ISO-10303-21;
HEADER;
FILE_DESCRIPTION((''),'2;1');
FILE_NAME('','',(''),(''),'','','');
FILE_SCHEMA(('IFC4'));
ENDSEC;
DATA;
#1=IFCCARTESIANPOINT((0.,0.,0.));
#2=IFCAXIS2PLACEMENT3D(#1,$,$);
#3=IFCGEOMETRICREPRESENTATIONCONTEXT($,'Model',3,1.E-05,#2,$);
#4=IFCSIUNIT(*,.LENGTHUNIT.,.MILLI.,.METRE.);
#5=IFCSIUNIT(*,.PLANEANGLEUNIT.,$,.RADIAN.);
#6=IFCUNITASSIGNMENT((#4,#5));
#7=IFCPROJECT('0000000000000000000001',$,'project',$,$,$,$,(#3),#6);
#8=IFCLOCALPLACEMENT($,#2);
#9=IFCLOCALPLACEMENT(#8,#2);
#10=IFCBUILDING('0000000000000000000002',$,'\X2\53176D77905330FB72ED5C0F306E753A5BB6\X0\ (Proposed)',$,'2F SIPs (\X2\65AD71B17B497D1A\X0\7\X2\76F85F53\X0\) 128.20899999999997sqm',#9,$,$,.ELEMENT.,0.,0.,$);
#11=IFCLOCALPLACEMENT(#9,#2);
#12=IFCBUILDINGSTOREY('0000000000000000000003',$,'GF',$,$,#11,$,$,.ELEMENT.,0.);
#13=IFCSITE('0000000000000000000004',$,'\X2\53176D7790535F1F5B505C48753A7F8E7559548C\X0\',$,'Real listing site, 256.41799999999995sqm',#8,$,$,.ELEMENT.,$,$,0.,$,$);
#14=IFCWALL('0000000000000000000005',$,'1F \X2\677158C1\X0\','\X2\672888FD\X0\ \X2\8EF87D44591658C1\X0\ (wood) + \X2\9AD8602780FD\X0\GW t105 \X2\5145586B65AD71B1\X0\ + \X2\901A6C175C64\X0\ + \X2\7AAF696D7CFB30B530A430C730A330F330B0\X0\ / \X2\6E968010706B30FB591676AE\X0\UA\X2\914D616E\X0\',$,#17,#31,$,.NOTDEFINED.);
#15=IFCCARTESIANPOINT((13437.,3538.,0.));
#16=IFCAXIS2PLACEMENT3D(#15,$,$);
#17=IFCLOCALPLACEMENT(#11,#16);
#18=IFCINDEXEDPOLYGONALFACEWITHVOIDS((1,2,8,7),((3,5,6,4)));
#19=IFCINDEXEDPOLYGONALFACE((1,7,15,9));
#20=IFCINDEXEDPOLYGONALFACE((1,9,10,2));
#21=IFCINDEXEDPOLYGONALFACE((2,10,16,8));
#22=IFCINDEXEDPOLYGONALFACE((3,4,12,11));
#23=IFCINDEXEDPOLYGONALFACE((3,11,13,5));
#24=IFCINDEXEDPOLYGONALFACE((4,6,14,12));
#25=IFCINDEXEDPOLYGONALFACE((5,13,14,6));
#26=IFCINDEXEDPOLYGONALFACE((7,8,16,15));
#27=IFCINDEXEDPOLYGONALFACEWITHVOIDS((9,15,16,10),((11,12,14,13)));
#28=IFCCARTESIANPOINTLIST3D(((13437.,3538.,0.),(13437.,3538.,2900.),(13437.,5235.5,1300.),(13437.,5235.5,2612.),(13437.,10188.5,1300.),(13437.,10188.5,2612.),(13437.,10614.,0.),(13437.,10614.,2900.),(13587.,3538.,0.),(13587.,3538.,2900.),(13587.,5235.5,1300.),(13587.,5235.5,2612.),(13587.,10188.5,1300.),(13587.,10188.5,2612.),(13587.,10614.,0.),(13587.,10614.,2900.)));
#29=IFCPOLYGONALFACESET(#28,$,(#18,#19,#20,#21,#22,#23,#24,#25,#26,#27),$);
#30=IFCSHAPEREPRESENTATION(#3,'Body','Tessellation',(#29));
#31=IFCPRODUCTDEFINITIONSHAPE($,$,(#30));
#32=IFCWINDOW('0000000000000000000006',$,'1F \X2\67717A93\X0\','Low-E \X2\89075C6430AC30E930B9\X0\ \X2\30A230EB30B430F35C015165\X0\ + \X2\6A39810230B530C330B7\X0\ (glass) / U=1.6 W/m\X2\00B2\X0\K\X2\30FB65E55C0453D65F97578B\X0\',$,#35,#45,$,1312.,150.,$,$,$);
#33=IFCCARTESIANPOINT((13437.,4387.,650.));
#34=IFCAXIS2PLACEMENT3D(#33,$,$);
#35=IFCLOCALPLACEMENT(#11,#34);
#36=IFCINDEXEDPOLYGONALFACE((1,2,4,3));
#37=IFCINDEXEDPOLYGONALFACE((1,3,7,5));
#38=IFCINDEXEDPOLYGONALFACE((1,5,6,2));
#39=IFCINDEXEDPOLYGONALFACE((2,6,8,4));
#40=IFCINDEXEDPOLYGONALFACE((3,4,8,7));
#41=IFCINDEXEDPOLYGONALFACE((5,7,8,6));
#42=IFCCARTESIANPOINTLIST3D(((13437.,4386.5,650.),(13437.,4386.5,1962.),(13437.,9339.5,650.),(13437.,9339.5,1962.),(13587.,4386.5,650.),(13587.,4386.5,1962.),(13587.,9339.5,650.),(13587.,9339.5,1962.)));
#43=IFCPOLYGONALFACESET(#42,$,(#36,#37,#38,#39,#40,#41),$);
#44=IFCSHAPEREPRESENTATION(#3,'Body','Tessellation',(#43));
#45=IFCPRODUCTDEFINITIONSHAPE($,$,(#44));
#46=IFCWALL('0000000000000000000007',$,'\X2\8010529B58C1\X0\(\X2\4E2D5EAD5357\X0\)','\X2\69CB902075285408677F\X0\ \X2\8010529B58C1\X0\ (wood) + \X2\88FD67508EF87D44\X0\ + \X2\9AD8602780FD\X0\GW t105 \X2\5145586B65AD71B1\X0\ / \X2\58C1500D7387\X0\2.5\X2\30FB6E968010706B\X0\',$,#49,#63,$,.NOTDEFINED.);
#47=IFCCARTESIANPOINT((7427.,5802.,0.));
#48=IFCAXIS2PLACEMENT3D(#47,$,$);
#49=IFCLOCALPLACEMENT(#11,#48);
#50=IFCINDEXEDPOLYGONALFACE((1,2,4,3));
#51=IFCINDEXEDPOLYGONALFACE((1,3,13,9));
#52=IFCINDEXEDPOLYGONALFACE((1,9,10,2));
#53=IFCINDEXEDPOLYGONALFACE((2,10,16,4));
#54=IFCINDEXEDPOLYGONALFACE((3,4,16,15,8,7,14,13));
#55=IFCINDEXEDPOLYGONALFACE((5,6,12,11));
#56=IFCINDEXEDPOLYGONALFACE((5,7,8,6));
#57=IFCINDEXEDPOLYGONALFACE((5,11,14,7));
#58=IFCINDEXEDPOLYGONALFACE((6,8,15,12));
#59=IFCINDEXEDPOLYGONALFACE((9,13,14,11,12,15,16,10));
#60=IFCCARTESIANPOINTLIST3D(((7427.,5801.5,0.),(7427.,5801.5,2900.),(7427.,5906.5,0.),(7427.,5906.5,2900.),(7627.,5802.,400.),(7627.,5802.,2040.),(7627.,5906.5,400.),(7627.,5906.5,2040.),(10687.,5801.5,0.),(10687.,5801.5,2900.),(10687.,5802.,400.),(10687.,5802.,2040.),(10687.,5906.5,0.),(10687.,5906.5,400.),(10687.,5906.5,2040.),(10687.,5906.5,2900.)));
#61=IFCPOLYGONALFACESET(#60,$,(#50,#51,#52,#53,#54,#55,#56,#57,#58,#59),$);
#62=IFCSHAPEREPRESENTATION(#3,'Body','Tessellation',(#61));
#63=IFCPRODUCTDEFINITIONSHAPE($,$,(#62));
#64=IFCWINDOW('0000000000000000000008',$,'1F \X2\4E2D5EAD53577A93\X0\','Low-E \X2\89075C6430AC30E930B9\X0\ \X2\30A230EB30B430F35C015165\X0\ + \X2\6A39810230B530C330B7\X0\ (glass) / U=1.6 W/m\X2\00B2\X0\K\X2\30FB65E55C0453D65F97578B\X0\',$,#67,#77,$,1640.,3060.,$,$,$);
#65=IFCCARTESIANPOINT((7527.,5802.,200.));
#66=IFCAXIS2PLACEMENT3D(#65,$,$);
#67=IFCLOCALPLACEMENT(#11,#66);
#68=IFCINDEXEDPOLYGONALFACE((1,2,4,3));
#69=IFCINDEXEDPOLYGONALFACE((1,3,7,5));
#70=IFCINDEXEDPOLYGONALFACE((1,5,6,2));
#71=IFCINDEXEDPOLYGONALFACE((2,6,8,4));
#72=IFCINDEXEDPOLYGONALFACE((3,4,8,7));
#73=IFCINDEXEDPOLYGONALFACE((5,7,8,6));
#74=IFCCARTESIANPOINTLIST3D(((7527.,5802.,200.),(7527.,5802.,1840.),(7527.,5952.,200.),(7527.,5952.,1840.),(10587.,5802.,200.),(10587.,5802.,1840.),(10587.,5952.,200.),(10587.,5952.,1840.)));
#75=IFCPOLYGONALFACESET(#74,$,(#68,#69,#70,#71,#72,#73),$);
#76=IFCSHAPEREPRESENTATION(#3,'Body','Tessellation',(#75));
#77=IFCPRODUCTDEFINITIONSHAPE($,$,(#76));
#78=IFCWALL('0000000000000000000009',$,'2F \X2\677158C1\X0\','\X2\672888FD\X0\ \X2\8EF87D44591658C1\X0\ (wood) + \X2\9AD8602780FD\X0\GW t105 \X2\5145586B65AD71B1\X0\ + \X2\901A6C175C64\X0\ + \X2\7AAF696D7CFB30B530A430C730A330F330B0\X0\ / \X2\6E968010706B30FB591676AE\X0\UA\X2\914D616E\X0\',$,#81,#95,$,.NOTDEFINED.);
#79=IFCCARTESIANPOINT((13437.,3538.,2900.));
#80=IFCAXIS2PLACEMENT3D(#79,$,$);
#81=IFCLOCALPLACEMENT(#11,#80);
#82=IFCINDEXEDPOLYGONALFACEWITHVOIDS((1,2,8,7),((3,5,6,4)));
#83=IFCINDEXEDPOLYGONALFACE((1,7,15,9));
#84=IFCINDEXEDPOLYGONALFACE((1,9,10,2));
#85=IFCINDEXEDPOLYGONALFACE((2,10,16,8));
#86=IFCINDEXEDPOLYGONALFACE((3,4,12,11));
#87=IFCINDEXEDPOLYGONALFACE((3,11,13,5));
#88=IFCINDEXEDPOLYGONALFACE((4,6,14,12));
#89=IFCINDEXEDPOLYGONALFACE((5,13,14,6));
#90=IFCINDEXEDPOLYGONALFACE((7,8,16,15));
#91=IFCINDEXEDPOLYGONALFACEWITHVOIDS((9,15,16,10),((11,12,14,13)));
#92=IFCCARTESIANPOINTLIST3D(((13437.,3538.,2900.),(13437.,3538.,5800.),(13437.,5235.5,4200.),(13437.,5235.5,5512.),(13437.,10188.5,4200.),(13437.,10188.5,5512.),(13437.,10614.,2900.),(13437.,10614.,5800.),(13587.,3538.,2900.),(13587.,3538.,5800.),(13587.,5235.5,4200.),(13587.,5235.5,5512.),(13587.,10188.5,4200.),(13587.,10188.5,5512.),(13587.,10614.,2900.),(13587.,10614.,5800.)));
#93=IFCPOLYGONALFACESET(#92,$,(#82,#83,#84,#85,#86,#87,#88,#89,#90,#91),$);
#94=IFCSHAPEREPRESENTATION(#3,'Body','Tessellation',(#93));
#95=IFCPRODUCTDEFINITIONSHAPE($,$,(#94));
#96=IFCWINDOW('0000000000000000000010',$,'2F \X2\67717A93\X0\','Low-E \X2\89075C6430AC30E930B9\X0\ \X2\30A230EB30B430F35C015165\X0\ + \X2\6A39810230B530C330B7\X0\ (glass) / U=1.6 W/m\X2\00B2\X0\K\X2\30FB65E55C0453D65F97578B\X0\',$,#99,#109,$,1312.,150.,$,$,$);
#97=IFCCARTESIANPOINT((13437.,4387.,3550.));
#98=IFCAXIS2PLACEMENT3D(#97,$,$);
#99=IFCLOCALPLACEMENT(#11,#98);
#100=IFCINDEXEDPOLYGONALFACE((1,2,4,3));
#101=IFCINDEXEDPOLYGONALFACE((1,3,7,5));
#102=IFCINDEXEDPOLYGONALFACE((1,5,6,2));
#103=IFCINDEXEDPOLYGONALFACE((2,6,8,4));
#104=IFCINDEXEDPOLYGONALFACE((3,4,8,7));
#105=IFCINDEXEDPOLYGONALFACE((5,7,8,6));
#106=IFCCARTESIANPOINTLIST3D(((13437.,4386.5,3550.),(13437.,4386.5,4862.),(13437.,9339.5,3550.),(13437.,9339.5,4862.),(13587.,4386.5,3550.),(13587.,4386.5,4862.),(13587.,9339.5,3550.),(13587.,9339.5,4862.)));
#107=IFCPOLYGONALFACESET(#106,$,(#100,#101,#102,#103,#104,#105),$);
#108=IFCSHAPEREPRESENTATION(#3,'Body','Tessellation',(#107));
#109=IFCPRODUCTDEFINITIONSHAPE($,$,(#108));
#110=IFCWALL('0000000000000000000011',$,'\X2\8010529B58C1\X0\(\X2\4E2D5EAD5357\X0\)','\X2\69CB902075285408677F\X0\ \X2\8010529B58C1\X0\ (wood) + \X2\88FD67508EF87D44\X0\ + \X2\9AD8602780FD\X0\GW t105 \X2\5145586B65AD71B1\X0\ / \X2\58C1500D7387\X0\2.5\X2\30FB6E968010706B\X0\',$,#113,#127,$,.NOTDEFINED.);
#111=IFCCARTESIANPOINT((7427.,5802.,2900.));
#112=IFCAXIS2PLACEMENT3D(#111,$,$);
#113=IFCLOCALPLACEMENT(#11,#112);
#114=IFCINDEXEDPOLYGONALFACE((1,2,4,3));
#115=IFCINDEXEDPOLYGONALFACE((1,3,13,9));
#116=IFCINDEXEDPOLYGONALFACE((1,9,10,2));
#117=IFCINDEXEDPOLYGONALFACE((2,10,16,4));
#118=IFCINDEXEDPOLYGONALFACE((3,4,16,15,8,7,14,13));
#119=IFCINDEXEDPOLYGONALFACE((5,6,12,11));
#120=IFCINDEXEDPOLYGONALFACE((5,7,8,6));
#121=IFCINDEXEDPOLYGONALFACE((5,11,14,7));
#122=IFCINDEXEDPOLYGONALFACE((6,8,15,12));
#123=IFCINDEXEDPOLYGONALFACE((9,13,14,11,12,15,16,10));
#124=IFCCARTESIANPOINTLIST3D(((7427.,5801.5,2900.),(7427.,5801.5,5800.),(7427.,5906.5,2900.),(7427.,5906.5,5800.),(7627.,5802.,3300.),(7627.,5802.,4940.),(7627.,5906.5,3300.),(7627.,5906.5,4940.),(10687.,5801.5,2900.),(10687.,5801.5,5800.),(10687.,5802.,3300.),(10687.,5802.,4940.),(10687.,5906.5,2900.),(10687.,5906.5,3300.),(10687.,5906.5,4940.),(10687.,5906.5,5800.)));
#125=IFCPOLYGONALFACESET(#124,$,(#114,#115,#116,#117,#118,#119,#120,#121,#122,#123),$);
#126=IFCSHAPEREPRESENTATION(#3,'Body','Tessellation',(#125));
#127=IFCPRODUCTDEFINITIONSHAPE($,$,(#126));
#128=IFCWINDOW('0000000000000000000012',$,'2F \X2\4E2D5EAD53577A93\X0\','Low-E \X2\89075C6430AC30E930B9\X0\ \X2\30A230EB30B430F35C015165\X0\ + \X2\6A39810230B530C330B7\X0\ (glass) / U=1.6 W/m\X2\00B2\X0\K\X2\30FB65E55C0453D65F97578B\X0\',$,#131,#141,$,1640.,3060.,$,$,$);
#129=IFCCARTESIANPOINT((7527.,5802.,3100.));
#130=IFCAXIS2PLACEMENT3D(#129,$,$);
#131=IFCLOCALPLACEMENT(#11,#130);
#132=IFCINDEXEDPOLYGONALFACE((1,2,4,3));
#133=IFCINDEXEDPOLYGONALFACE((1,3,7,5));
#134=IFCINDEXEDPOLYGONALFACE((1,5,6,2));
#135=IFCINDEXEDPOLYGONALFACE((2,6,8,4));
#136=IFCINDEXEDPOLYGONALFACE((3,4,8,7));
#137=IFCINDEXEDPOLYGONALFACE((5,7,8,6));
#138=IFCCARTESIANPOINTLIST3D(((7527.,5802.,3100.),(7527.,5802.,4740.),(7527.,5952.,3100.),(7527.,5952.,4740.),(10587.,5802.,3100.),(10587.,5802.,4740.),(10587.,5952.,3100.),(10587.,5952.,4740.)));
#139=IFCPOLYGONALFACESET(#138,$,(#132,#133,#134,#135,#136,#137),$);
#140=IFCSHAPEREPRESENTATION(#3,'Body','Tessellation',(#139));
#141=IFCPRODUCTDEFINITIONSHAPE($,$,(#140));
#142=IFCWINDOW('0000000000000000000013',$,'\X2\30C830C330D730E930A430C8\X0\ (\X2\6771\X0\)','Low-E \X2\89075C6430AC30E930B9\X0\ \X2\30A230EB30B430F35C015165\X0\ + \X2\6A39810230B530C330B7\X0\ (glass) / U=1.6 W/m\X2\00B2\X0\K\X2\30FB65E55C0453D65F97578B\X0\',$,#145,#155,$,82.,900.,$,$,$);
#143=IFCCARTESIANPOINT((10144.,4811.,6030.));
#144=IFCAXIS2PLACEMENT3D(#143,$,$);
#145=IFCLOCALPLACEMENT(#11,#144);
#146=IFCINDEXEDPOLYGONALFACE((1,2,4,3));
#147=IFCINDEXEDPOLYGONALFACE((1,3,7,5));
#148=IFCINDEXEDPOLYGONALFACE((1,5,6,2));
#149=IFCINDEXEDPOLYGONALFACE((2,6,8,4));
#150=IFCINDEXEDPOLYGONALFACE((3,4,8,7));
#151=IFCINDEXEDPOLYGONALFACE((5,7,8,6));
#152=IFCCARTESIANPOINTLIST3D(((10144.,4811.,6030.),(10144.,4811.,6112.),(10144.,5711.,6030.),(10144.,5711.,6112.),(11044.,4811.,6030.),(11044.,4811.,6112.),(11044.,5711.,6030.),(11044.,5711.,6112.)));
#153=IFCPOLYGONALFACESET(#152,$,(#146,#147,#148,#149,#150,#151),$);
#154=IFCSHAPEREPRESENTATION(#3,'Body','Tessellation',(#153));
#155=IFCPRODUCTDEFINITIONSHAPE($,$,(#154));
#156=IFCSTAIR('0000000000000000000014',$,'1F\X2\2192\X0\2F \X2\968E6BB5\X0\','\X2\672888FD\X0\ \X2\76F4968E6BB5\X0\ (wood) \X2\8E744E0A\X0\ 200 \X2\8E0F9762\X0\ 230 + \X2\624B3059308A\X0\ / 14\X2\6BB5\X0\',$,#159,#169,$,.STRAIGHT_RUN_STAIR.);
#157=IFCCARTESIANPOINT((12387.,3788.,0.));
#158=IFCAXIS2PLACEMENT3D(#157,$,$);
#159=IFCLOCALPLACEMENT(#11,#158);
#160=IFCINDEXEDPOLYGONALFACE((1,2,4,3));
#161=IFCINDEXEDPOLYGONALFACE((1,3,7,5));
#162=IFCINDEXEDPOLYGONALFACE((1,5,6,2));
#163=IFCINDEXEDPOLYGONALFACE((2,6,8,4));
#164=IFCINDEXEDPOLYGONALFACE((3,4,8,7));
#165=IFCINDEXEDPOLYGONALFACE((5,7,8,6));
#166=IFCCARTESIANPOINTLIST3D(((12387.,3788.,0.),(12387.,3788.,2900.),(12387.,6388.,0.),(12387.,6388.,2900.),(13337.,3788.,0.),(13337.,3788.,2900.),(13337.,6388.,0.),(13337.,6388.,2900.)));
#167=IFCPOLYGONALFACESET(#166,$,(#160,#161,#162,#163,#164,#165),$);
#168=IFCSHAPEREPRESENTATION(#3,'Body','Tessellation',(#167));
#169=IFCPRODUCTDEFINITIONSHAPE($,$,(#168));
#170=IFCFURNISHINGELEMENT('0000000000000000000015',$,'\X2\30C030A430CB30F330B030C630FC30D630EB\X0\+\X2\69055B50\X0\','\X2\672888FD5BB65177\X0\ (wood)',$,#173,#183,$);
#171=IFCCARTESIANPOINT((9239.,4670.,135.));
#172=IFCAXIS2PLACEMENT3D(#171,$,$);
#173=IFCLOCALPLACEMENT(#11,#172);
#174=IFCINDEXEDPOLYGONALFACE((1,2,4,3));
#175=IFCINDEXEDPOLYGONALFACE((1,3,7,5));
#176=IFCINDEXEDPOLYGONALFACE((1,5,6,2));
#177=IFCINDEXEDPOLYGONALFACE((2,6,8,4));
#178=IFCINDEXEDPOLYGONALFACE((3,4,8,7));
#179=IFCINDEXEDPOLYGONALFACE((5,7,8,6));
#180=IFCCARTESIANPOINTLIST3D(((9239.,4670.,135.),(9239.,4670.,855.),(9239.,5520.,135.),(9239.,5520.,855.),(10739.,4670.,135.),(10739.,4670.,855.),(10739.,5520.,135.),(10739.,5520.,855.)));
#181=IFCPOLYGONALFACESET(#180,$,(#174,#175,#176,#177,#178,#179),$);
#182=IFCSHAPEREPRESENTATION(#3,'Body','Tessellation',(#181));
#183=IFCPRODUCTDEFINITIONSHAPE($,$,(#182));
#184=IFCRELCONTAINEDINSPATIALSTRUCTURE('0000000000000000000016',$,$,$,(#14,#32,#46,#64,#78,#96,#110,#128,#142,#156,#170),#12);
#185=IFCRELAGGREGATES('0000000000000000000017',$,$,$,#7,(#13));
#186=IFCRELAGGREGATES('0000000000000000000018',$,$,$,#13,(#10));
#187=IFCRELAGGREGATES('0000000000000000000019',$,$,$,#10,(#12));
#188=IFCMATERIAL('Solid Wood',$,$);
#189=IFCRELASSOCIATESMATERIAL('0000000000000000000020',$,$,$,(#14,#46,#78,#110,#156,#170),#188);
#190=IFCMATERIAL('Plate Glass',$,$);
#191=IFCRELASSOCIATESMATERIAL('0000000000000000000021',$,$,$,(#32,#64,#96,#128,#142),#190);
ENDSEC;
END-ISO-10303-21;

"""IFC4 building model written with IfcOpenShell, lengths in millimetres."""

from ifc_helpers import new_model, si_unit, frame, frame_2d, origin, place, context, project, spatial, rectangle, extrude, material, element, fill, save


model = new_model("IFC4")

# Units and contexts
model_context = context("Model", 3, precision=1e-05, world=origin())
ifc_project = project(units=[si_unit("LENGTHUNIT", "METRE", prefix="MILLI"), si_unit("PLANEANGLEUNIT", "RADIAN")], contexts=[model_context])

# Site, building, storey
site_placement = place(None, origin())
site = spatial("IfcSite", under=ifc_project, at=site_placement, Name="北海道弟子屈町美留和", ObjectType="Real listing site, 256.41799999999995sqm", CompositionType="ELEMENT", RefElevation=0.0)
building_placement = place(site_placement, origin())
building = spatial("IfcBuilding", under=site, at=building_placement, Name="北海道・狭小の町家 (Proposed)", ObjectType="2F SIPs (断熱等級7相当) 128.20899999999997sqm", CompositionType="ELEMENT", ElevationOfRefHeight=0.0, ElevationOfTerrain=0.0)
storey_placement = place(building_placement, origin())
storey = spatial("IfcBuildingStorey", under=building, at=storey_placement, Name="GF", CompositionType="ELEMENT", Elevation=0.0)

# Shared definitions
ifc_material_1 = material(Name="Solid Wood")

# Walls, openings, windows
wall_1_placement = place(storey_placement, frame((13437.0, 3538.0, 0.0)))
wall_1 = element("IfcWall", 1, at=wall_1_placement, inside=storey, material=ifc_material_1, Name="1F 東壁", Description="木製 軸組外壁 (wood) + 高性能GW t105 充填断熱 + 通気層 + 窯業系サイディング / 準耐火・外皮UA配慮", PredefinedType="NOTDEFINED", context=model_context, shape_type="SweptSolid", body=[
    extrude(rectangle(XDim=150.0, YDim=7076.0, at=frame_2d((75.0, 3538.0))), frame((13437.0, 3538.0, 0.0)), (0.0, 0.0, 1.0), 2900.0),
])
opening_1_placement = place(storey_placement, frame((13437.0, 4387.0, 650.0)))
opening_1 = element("IfcOpeningElement", 2, at=opening_1_placement, cuts=wall_1, PredefinedType="NOTDEFINED", context=model_context, shape_type="SweptSolid", body=[
    extrude(rectangle(XDim=150.0, YDim=4953.0, at=frame_2d((75.0, 2476.0))), frame((13437.0, 4387.0, 650.0)), (0.0, 0.0, 1.0), 1312.0),
])
ifc_material_2 = material(Name="Plate Glass")
window_1_placement = place(storey_placement, frame((13437.0, 4387.0, 650.0)))
window_1 = element("IfcWindow", 3, at=window_1_placement, inside=storey, material=ifc_material_2, Name="1F 東窓", Description="Low-E 複層ガラス アルゴン封入 + 樹脂サッシ (glass) / U=1.6 W/m²K・日射取得型", OverallHeight=1312.0, OverallWidth=150.0, context=model_context, shape_type="SweptSolid", body=[
    extrude(rectangle(XDim=150.0, YDim=4953.0, at=frame_2d((75.0, 2476.0))), frame((13437.0, 4387.0, 650.0)), (0.0, 0.0, 1.0), 1312.0),
])
fill(opening_1, window_1)
wall_2_placement = place(storey_placement, frame((7427.0, 5802.0, 0.0)))
wall_2 = element("IfcWall", 4, at=wall_2_placement, inside=storey, material=ifc_material_1, Name="耐力壁(中庭南)", Description="構造用合板 耐力壁 (wood) + 製材軸組 + 高性能GW t105 充填断熱 / 壁倍率2.5・準耐火", PredefinedType="NOTDEFINED", context=model_context, shape_type="SweptSolid", body=[
    extrude(rectangle(XDim=3260.0, YDim=105.0, at=frame_2d((1630.0, 52.0))), frame((7427.0, 5802.0, 0.0)), (0.0, 0.0, 1.0), 2900.0),
])
opening_2_placement = place(storey_placement, frame((7527.0, 5802.0, 200.0)))
opening_2 = element("IfcOpeningElement", 5, at=opening_2_placement, cuts=wall_2, PredefinedType="NOTDEFINED", context=model_context, shape_type="SweptSolid", body=[
    extrude(rectangle(XDim=3060.0, YDim=150.0, at=frame_2d((1530.0, 75.0))), frame((7527.0, 5802.0, 200.0)), (0.0, 0.0, 1.0), 1640.0),
])
window_2_placement = place(storey_placement, frame((7527.0, 5802.0, 200.0)))
window_2 = element("IfcWindow", 6, at=window_2_placement, inside=storey, material=ifc_material_2, Name="1F 中庭南窓", Description="Low-E 複層ガラス アルゴン封入 + 樹脂サッシ (glass) / U=1.6 W/m²K・日射取得型", OverallHeight=1640.0, OverallWidth=3060.0, context=model_context, shape_type="SweptSolid", body=[
    extrude(rectangle(XDim=3060.0, YDim=150.0, at=frame_2d((1530.0, 75.0))), frame((7527.0, 5802.0, 200.0)), (0.0, 0.0, 1.0), 1640.0),
])
fill(opening_2, window_2)

# Walls, openings, windows
wall_3_placement = place(storey_placement, frame((13437.0, 3538.0, 2900.0)))
wall_3 = element("IfcWall", 7, at=wall_3_placement, inside=storey, material=ifc_material_1, Name="2F 東壁", Description="木製 軸組外壁 (wood) + 高性能GW t105 充填断熱 + 通気層 + 窯業系サイディング / 準耐火・外皮UA配慮", PredefinedType="NOTDEFINED", context=model_context, shape_type="SweptSolid", body=[
    extrude(rectangle(XDim=150.0, YDim=7076.0, at=frame_2d((75.0, 3538.0))), frame((13437.0, 3538.0, 2900.0)), (0.0, 0.0, 1.0), 2900.0),
])
opening_3_placement = place(storey_placement, frame((13437.0, 4387.0, 3550.0)))
opening_3 = element("IfcOpeningElement", 8, at=opening_3_placement, cuts=wall_3, PredefinedType="NOTDEFINED", context=model_context, shape_type="SweptSolid", body=[
    extrude(rectangle(XDim=150.0, YDim=4953.0, at=frame_2d((75.0, 2476.0))), frame((13437.0, 4387.0, 3550.0)), (0.0, 0.0, 1.0), 1312.0),
])
window_3_placement = place(storey_placement, frame((13437.0, 4387.0, 3550.0)))
window_3 = element("IfcWindow", 9, at=window_3_placement, inside=storey, material=ifc_material_2, Name="2F 東窓", Description="Low-E 複層ガラス アルゴン封入 + 樹脂サッシ (glass) / U=1.6 W/m²K・日射取得型", OverallHeight=1312.0, OverallWidth=150.0, context=model_context, shape_type="SweptSolid", body=[
    extrude(rectangle(XDim=150.0, YDim=4953.0, at=frame_2d((75.0, 2476.0))), frame((13437.0, 4387.0, 3550.0)), (0.0, 0.0, 1.0), 1312.0),
])
fill(opening_3, window_3)
wall_4_placement = place(storey_placement, frame((7427.0, 5802.0, 2900.0)))
wall_4 = element("IfcWall", 10, at=wall_4_placement, inside=storey, material=ifc_material_1, Name="耐力壁(中庭南)", Description="構造用合板 耐力壁 (wood) + 製材軸組 + 高性能GW t105 充填断熱 / 壁倍率2.5・準耐火", PredefinedType="NOTDEFINED", context=model_context, shape_type="SweptSolid", body=[
    extrude(rectangle(XDim=3260.0, YDim=105.0, at=frame_2d((1630.0, 52.0))), frame((7427.0, 5802.0, 2900.0)), (0.0, 0.0, 1.0), 2900.0),
])
opening_4_placement = place(storey_placement, frame((7527.0, 5802.0, 3100.0)))
opening_4 = element("IfcOpeningElement", 11, at=opening_4_placement, cuts=wall_4, PredefinedType="NOTDEFINED", context=model_context, shape_type="SweptSolid", body=[
    extrude(rectangle(XDim=3060.0, YDim=150.0, at=frame_2d((1530.0, 75.0))), frame((7527.0, 5802.0, 3100.0)), (0.0, 0.0, 1.0), 1640.0),
])
window_4_placement = place(storey_placement, frame((7527.0, 5802.0, 3100.0)))
window_4 = element("IfcWindow", 12, at=window_4_placement, inside=storey, material=ifc_material_2, Name="2F 中庭南窓", Description="Low-E 複層ガラス アルゴン封入 + 樹脂サッシ (glass) / U=1.6 W/m²K・日射取得型", OverallHeight=1640.0, OverallWidth=3060.0, context=model_context, shape_type="SweptSolid", body=[
    extrude(rectangle(XDim=3060.0, YDim=150.0, at=frame_2d((1530.0, 75.0))), frame((7527.0, 5802.0, 3100.0)), (0.0, 0.0, 1.0), 1640.0),
])
fill(opening_4, window_4)

# Window
window_5_placement = place(storey_placement, frame((10144.0, 4811.0, 6030.0)))
element("IfcWindow", 13, at=window_5_placement, inside=storey, material=ifc_material_2, Name="トップライト (東)", Description="Low-E 複層ガラス アルゴン封入 + 樹脂サッシ (glass) / U=1.6 W/m²K・日射取得型", OverallHeight=82.0, OverallWidth=900.0, context=model_context, shape_type="SweptSolid", body=[
    extrude(rectangle(XDim=900.0, YDim=900.0, at=frame_2d((450.0, 450.0))), frame((10144.0, 4811.0, 6030.0)), (0.0, 0.0, 1.0), 82.0),
])

# Stair
stair_placement = place(storey_placement, frame((12387.0, 3788.0, 0.0)))
element("IfcStair", 14, at=stair_placement, inside=storey, material=ifc_material_1, Name="1F→2F 階段", Description="木製 直階段 (wood) 蹴上 200 踏面 230 + 手すり / 14段", PredefinedType="STRAIGHT_RUN_STAIR", context=model_context, shape_type="SweptSolid", body=[
    extrude(rectangle(XDim=950.0, YDim=2600.0, at=frame_2d((475.0, 1300.0))), frame((12387.0, 3788.0, 0.0)), (0.0, 0.0, 1.0), 2900.0),
])

# Furnishing element
furnishing_1_placement = place(storey_placement, frame((9239.0, 4670.0, 135.0)))
element("IfcFurnishingElement", 15, at=furnishing_1_placement, inside=storey, material=ifc_material_1, Name="ダイニングテーブル+椅子", Description="木製家具 (wood)", context=model_context, shape_type="SweptSolid", body=[
    extrude(rectangle(XDim=1500.0, YDim=850.0, at=frame_2d((750.0, 425.0))), frame((9239.0, 4670.0, 135.0)), (0.0, 0.0, 1.0), 720.0),
])

save(model, "model.ifc")
